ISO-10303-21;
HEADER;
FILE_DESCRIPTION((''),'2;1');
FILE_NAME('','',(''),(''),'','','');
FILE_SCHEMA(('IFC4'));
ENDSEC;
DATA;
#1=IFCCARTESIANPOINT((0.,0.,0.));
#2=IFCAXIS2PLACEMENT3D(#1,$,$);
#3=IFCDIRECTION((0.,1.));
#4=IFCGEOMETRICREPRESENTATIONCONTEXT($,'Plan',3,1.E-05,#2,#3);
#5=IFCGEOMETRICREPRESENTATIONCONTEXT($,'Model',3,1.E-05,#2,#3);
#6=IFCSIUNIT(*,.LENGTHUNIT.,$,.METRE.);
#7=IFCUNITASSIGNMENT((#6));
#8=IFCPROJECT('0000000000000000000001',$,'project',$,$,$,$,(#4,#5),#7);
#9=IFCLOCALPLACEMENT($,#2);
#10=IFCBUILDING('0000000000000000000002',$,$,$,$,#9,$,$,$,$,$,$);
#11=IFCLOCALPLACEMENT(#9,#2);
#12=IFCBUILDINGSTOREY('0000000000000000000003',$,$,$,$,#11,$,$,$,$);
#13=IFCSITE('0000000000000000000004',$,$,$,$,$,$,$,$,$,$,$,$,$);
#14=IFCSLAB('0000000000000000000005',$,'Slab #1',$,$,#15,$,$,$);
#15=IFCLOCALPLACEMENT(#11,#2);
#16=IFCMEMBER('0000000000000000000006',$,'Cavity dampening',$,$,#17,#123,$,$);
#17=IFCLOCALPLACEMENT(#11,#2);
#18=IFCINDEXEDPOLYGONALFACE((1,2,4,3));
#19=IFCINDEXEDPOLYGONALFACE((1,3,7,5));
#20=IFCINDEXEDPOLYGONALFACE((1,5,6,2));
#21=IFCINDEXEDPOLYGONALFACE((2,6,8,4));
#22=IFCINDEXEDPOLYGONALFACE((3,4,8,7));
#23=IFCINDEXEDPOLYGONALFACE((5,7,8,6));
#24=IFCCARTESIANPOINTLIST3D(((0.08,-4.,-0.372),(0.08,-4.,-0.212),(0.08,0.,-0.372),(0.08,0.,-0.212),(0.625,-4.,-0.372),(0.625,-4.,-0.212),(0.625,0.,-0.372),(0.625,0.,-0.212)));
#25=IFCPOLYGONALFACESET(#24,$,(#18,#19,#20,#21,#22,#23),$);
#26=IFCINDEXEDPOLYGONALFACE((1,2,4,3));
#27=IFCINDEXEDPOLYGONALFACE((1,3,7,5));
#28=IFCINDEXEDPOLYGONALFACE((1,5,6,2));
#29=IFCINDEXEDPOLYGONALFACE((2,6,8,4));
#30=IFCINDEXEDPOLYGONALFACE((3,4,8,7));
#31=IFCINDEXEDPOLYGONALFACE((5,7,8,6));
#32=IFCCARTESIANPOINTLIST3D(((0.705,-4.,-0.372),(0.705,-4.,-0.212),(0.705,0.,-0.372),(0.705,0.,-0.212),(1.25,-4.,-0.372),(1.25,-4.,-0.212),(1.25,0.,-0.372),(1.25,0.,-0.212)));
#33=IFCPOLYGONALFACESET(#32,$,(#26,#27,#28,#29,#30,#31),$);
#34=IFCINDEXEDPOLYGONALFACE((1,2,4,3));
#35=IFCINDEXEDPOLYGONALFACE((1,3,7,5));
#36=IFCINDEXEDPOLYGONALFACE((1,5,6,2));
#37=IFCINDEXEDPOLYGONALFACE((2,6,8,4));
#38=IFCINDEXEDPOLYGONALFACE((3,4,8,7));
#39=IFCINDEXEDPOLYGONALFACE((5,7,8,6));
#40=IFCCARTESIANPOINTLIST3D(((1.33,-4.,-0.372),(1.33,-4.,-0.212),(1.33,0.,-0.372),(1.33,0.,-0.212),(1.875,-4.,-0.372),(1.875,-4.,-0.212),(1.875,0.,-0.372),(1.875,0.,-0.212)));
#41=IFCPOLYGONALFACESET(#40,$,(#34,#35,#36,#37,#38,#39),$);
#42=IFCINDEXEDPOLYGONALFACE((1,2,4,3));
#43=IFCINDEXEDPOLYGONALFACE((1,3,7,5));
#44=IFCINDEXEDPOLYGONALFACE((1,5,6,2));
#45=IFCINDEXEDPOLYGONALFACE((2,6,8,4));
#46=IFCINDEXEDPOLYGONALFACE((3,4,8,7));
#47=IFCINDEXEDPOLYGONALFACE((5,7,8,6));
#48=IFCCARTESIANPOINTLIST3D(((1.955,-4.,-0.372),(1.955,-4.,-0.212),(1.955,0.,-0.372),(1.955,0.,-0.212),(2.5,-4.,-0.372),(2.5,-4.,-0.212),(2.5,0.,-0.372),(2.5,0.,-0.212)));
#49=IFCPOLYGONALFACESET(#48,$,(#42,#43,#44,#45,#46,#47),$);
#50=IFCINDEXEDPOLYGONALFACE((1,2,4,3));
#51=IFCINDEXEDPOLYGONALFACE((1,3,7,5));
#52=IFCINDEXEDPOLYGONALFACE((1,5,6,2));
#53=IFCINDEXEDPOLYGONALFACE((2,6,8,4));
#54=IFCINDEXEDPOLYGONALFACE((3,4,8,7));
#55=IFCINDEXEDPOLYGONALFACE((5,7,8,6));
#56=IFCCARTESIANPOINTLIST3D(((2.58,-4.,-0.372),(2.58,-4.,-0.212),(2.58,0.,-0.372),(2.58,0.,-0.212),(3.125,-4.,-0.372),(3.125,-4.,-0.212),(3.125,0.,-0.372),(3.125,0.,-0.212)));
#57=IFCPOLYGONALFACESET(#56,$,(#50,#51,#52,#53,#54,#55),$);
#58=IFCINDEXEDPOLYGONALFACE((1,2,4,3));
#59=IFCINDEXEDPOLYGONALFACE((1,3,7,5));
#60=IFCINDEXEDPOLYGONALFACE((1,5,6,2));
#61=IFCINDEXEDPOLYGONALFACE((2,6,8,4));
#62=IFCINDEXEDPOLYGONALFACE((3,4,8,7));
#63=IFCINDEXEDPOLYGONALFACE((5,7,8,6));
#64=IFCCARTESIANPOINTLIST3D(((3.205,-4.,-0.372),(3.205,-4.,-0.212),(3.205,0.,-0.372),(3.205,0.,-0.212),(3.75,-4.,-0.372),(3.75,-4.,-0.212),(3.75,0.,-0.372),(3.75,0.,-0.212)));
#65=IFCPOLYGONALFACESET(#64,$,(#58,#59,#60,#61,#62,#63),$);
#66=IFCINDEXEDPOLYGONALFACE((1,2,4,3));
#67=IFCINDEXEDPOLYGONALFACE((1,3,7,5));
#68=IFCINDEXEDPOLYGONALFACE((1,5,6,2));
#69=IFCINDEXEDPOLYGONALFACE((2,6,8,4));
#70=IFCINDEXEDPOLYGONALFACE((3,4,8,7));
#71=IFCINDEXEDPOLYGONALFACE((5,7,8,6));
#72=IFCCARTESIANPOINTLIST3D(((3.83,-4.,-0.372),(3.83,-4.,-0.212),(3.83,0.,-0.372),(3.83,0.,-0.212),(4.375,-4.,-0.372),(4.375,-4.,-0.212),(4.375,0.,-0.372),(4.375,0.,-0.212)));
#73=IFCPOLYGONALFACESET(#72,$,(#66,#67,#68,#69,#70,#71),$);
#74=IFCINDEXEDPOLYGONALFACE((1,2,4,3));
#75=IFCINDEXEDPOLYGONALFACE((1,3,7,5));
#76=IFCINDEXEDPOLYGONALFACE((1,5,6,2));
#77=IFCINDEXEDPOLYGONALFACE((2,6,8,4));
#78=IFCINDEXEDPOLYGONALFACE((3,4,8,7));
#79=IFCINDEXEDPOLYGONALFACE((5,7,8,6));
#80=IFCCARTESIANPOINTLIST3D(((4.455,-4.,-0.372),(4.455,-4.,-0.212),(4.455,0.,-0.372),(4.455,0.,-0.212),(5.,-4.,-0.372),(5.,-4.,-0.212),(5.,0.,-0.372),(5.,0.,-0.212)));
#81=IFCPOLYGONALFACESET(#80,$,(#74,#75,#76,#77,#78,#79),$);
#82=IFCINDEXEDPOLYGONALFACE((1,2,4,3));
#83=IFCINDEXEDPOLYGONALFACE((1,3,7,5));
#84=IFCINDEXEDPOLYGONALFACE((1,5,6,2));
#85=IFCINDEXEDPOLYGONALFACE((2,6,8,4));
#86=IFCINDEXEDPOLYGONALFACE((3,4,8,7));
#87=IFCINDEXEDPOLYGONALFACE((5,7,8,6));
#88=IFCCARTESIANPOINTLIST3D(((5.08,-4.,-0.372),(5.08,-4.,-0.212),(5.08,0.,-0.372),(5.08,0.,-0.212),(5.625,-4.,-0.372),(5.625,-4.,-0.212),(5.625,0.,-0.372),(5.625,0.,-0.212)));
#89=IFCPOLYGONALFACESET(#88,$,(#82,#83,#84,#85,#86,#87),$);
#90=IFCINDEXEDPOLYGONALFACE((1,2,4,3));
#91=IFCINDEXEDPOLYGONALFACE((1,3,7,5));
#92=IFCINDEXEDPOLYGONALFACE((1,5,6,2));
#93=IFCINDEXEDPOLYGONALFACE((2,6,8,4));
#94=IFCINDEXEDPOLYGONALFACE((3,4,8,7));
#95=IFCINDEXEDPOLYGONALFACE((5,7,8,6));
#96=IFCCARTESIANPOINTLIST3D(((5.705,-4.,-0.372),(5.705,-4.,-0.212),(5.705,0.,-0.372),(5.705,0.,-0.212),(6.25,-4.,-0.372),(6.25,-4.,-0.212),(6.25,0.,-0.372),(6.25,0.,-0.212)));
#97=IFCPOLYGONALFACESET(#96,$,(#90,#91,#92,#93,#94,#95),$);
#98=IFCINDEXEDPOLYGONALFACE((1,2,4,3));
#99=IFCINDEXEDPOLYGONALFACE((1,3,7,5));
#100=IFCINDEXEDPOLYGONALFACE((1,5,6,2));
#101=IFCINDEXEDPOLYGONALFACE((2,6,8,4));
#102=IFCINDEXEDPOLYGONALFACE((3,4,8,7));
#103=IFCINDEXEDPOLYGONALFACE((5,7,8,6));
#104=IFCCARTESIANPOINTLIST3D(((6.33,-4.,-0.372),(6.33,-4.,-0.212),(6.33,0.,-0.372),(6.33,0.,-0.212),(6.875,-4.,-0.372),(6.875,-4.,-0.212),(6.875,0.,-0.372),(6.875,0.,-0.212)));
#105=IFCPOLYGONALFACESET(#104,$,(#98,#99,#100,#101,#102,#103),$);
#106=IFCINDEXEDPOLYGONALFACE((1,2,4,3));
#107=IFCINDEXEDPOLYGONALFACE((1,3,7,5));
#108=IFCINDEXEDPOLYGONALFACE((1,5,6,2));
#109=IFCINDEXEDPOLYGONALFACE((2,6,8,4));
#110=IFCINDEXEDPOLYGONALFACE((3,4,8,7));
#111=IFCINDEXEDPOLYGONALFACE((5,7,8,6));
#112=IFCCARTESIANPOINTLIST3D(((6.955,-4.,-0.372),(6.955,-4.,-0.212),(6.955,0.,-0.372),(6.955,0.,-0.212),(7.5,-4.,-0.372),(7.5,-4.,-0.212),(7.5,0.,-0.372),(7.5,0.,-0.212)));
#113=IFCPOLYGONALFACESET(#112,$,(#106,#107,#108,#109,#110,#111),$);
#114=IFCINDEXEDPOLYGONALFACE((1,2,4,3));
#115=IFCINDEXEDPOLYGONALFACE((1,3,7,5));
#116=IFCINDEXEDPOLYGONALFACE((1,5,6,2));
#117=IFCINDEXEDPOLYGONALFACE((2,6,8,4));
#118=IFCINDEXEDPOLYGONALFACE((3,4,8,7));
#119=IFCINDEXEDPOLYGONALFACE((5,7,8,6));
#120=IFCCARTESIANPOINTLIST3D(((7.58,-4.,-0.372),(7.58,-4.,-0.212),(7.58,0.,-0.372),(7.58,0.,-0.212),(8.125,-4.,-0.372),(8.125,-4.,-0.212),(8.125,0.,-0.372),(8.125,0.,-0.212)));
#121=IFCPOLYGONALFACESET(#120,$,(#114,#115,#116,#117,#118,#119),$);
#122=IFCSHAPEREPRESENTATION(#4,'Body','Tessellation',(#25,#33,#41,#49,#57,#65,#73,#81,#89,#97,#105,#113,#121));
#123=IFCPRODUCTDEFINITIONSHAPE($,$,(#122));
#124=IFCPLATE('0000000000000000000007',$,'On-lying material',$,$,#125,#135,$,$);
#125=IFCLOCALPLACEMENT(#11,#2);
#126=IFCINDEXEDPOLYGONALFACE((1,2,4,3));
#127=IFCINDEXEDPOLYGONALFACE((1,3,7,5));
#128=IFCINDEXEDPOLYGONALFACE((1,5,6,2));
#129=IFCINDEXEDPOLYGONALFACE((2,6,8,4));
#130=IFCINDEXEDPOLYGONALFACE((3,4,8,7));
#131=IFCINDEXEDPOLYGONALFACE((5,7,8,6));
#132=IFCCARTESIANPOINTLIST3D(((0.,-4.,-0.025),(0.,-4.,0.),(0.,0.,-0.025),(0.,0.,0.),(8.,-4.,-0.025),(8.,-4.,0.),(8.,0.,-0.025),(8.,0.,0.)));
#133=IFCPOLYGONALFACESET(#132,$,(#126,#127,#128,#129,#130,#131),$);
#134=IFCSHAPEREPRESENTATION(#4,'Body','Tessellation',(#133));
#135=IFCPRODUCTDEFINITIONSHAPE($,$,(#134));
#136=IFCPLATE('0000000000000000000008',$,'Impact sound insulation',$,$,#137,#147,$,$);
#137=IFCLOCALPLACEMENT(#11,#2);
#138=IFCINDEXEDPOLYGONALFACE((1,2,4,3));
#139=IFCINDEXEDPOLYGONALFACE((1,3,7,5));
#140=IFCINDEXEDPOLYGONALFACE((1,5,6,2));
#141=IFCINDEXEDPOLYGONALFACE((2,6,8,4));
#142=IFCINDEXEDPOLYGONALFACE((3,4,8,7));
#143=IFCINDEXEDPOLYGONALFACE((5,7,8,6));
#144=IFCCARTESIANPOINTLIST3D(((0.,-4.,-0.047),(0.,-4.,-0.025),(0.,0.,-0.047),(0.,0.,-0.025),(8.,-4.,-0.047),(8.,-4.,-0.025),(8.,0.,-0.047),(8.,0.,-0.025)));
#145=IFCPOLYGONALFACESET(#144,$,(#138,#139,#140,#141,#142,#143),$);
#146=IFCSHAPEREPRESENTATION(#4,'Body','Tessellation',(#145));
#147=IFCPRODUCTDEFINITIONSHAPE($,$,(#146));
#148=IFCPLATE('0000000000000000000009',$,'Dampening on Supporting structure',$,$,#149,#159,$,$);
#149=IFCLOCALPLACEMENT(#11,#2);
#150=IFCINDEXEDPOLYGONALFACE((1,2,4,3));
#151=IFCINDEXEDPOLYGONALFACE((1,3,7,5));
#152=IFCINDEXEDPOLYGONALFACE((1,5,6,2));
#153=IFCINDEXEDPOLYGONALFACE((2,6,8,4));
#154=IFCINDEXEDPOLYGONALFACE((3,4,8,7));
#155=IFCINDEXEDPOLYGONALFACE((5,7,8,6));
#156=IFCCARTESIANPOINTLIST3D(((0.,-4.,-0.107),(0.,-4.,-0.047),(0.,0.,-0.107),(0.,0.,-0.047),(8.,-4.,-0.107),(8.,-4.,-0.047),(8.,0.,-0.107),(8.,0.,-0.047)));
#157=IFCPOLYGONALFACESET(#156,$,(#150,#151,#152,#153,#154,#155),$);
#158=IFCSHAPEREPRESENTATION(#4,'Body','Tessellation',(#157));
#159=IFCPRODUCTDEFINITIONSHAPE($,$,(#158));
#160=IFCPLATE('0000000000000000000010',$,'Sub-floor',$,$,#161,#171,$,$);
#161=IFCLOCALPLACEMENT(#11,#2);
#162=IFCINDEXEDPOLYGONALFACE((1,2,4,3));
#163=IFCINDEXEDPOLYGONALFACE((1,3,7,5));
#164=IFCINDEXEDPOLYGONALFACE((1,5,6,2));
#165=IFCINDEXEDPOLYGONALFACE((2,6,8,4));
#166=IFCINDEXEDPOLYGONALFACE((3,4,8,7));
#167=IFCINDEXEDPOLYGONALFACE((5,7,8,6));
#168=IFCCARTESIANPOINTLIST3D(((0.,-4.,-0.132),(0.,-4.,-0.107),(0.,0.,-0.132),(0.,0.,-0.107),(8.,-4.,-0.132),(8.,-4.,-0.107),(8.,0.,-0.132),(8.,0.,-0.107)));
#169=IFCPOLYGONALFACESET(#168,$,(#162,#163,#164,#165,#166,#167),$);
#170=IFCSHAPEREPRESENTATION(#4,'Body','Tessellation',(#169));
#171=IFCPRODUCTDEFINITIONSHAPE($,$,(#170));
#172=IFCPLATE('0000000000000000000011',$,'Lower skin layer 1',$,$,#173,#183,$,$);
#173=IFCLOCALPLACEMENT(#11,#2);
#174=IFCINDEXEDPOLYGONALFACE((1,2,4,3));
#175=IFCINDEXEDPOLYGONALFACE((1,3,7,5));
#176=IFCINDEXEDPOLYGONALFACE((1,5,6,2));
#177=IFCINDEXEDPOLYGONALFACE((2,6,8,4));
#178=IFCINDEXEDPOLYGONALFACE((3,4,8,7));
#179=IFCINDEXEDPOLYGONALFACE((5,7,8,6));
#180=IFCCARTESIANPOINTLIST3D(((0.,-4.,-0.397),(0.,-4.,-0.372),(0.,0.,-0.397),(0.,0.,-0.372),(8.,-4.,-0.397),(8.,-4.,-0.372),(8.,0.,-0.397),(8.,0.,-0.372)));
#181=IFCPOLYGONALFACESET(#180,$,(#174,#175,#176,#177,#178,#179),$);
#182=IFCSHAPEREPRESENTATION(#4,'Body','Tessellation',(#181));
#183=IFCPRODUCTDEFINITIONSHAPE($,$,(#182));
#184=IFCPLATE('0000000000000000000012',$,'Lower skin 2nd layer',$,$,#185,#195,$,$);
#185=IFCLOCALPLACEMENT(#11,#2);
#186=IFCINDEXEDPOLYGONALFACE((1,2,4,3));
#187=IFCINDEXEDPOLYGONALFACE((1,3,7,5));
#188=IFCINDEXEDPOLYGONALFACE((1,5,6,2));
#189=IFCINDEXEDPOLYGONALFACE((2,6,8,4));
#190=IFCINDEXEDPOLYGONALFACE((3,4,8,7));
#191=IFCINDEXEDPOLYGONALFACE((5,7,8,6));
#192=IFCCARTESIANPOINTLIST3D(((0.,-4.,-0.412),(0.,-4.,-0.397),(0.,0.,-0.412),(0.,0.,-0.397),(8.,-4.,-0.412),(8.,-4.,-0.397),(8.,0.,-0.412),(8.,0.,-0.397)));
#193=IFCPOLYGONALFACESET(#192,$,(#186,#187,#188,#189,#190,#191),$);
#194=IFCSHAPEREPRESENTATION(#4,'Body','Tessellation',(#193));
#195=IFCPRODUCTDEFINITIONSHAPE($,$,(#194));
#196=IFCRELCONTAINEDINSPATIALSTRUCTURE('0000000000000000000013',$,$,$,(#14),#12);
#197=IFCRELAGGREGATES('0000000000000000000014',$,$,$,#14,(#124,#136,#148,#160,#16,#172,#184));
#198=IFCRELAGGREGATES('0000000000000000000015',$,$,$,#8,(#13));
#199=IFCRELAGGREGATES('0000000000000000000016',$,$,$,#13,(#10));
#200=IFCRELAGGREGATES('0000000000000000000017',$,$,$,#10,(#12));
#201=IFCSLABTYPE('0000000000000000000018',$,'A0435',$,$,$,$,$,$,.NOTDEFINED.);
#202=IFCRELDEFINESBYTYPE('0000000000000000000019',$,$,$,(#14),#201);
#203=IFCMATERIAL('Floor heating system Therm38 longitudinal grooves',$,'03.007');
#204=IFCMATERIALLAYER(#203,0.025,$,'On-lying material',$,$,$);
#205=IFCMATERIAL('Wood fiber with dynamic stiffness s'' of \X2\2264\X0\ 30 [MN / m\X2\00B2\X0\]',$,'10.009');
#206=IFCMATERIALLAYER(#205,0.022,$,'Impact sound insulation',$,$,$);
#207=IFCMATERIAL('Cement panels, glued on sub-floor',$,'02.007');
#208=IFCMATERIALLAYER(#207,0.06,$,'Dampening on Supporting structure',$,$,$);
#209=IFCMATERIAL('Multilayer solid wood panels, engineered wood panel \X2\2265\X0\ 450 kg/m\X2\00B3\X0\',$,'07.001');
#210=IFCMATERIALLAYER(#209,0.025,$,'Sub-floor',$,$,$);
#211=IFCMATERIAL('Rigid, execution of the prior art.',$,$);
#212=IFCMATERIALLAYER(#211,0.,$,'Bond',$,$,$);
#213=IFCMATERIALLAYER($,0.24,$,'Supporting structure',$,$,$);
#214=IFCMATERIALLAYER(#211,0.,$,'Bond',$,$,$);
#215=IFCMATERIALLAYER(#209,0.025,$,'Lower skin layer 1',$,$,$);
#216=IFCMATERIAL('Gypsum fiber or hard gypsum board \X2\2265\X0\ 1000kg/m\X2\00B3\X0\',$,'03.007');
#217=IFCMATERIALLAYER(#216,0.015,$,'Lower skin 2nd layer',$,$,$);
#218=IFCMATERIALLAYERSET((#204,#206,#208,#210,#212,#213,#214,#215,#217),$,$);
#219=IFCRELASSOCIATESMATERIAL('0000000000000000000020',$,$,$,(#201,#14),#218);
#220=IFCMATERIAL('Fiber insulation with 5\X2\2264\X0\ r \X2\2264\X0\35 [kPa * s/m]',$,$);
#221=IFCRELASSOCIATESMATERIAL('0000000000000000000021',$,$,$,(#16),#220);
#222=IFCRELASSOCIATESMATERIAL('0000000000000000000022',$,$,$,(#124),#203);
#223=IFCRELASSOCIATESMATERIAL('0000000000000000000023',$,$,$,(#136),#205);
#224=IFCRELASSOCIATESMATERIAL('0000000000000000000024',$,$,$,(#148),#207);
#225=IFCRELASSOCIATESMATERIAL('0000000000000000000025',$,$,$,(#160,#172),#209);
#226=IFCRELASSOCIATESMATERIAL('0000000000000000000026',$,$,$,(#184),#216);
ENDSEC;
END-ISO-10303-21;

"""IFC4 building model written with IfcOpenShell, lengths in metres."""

from ifc_helpers import new_model, si_unit, direction, frame, frame_2d, origin, origin_with_axes, place, context, project, spatial, rectangle, extrude, material, layer, layer_set, type_object, element, aggregate, save


model = new_model("IFC4")

# Units and contexts
plan_context = context("Plan", 3, precision=1e-05, world=origin(), true_north=direction((0.0, 1.0)))
model_context = context("Model", 3, precision=1e-05, world=origin(), true_north=direction((0.0, 1.0)))
ifc_project = project(units=[si_unit("LENGTHUNIT", "METRE")], contexts=[plan_context, model_context])

# Site, building, storey
site = spatial("IfcSite", under=ifc_project)
building_placement = place(None, origin())
building = spatial("IfcBuilding", under=site, at=building_placement)
storey_placement = place(building_placement, origin())
storey = spatial("IfcBuildingStorey", under=building, at=storey_placement)

# Slab, member, plates
ifc_material_1 = material(Name="Floor heating system Therm38 longitudinal grooves", Category="03.007")
ifc_layer_1 = layer(ifc_material_1, 0.025, Name="On-lying material")
ifc_material_2 = material(Name="Wood fiber with dynamic stiffness s' of ≤ 30 [MN / m²]", Category="10.009")
ifc_layer_2 = layer(ifc_material_2, 0.022, Name="Impact sound insulation")
ifc_material_3 = material(Name="Cement panels, glued on sub-floor", Category="02.007")
ifc_layer_3 = layer(ifc_material_3, 0.06, Name="Dampening on Supporting structure")
ifc_material_4 = material(Name="Multilayer solid wood panels, engineered wood panel ≥ 450 kg/m³", Category="07.001")
ifc_layer_4 = layer(ifc_material_4, 0.025, Name="Sub-floor")
ifc_material_5 = material(Name="Rigid, execution of the prior art.")
ifc_layer_5 = layer(ifc_material_5, 0.0, Name="Bond")
ifc_layer_6 = layer(None, 0.24, Name="Supporting structure")
ifc_layer_7 = layer(ifc_material_5, 0.0, Name="Bond")
ifc_layer_8 = layer(ifc_material_4, 0.025, Name="Lower skin layer 1")
ifc_material_6 = material(Name="Gypsum fiber or hard gypsum board ≥ 1000kg/m³", Category="03.007")
ifc_layer_9 = layer(ifc_material_6, 0.015, Name="Lower skin 2nd layer")
ifc_layer_set = layer_set([ifc_layer_1, ifc_layer_2, ifc_layer_3, ifc_layer_4, ifc_layer_5, ifc_layer_6, ifc_layer_7, ifc_layer_8, ifc_layer_9])
slab_type = type_object("IfcSlabType", Name="A0435", PredefinedType="NOTDEFINED", material=ifc_layer_set)
slab_placement = place(None, frame((0.0, 0.0, 0.0), z_axis=(0.0, 0.0, -1.0), x_axis=(1.0, 0.0, 0.0)))
slab = element("IfcSlab", 1, at=slab_placement, inside=storey, type_object=slab_type, material=ifc_layer_set, Name="Slab #1")
ifc_material_7 = material(Name="Fiber insulation with 5≤ r ≤35 [kPa * s/m]")
member_1_placement = place(slab_placement, origin())
member_1 = element("IfcMember", 2, at=member_1_placement, material=ifc_material_7, Name="Cavity dampening", context=plan_context, shape_type="SweptSolid", body=[
    extrude(rectangle(XDim=0.545, YDim=0.16, at=frame_2d((0.2725, 0.08), x_axis=(1.0, 0.0))), frame((0.08, 4.0, 0.212), z_axis=(0.0, -1.0, 0.0), x_axis=(1.0, 0.0, 0.0)), (0.0, 0.0, 1.0), 4.0),
    extrude(rectangle(XDim=0.545, YDim=0.16, at=frame_2d((0.2725, 0.08), x_axis=(1.0, 0.0))), frame((0.705, 4.0, 0.212), z_axis=(0.0, -1.0, 0.0), x_axis=(1.0, 0.0, 0.0)), (0.0, 0.0, 1.0), 4.0),
    extrude(rectangle(XDim=0.545, YDim=0.16, at=frame_2d((0.2725, 0.08), x_axis=(1.0, 0.0))), frame((1.33, 4.0, 0.212), z_axis=(0.0, -1.0, 0.0), x_axis=(1.0, 0.0, 0.0)), (0.0, 0.0, 1.0), 4.0),
    extrude(rectangle(XDim=0.545, YDim=0.16, at=frame_2d((0.2725, 0.08), x_axis=(1.0, 0.0))), frame((1.955, 4.0, 0.212), z_axis=(0.0, -1.0, 0.0), x_axis=(1.0, 0.0, 0.0)), (0.0, 0.0, 1.0), 4.0),
    extrude(rectangle(XDim=0.545, YDim=0.16, at=frame_2d((0.2725, 0.08), x_axis=(1.0, 0.0))), frame((2.58, 4.0, 0.212), z_axis=(0.0, -1.0, 0.0), x_axis=(1.0, 0.0, 0.0)), (0.0, 0.0, 1.0), 4.0),
    extrude(rectangle(XDim=0.545, YDim=0.16, at=frame_2d((0.2725, 0.08), x_axis=(1.0, 0.0))), frame((3.205, 4.0, 0.212), z_axis=(0.0, -1.0, 0.0), x_axis=(1.0, 0.0, 0.0)), (0.0, 0.0, 1.0), 4.0),
    extrude(rectangle(XDim=0.545, YDim=0.16, at=frame_2d((0.2725, 0.08), x_axis=(1.0, 0.0))), frame((3.83, 4.0, 0.212), z_axis=(0.0, -1.0, 0.0), x_axis=(1.0, 0.0, 0.0)), (0.0, 0.0, 1.0), 4.0),
    extrude(rectangle(XDim=0.545, YDim=0.16, at=frame_2d((0.2725, 0.08), x_axis=(1.0, 0.0))), frame((4.455, 4.0, 0.212), z_axis=(0.0, -1.0, 0.0), x_axis=(1.0, 0.0, 0.0)), (0.0, 0.0, 1.0), 4.0),
    extrude(rectangle(XDim=0.545, YDim=0.16, at=frame_2d((0.2725, 0.08), x_axis=(1.0, 0.0))), frame((5.08, 4.0, 0.212), z_axis=(0.0, -1.0, 0.0), x_axis=(1.0, 0.0, 0.0)), (0.0, 0.0, 1.0), 4.0),
    extrude(rectangle(XDim=0.545, YDim=0.16, at=frame_2d((0.2725, 0.08), x_axis=(1.0, 0.0))), frame((5.705, 4.0, 0.212), z_axis=(0.0, -1.0, 0.0), x_axis=(1.0, 0.0, 0.0)), (0.0, 0.0, 1.0), 4.0),
    extrude(rectangle(XDim=0.545, YDim=0.16, at=frame_2d((0.2725, 0.08), x_axis=(1.0, 0.0))), frame((6.33, 4.0, 0.212), z_axis=(0.0, -1.0, 0.0), x_axis=(1.0, 0.0, 0.0)), (0.0, 0.0, 1.0), 4.0),
    extrude(rectangle(XDim=0.545, YDim=0.16, at=frame_2d((0.2725, 0.08), x_axis=(1.0, 0.0))), frame((6.955, 4.0, 0.212), z_axis=(0.0, -1.0, 0.0), x_axis=(1.0, 0.0, 0.0)), (0.0, 0.0, 1.0), 4.0),
    extrude(rectangle(XDim=0.545, YDim=0.16, at=frame_2d((0.2725, 0.08), x_axis=(1.0, 0.0))), frame((7.58, 4.0, 0.212), z_axis=(0.0, -1.0, 0.0), x_axis=(1.0, 0.0, 0.0)), (0.0, 0.0, 1.0), 4.0),
])
plate_1_placement = place(slab_placement, origin())
plate_1 = element("IfcPlate", 3, at=plate_1_placement, material=ifc_material_1, Name="On-lying material", context=plan_context, shape_type="SweptSolid", body=[
    extrude(rectangle(XDim=8.0, YDim=4.0, at=frame_2d((4.0, 2.0), x_axis=(1.0, 0.0))), origin_with_axes(), (0.0, 0.0, 1.0), 0.025),
])
plate_2_placement = place(slab_placement, origin())
plate_2 = element("IfcPlate", 4, at=plate_2_placement, material=ifc_material_2, Name="Impact sound insulation", context=plan_context, shape_type="SweptSolid", body=[
    extrude(rectangle(XDim=8.0, YDim=4.0, at=frame_2d((4.0, 2.0), x_axis=(1.0, 0.0))), frame((0.0, 0.0, 0.025), z_axis=(0.0, 0.0, 1.0), x_axis=(1.0, 0.0, 0.0)), (0.0, 0.0, 1.0), 0.022),
])
plate_3_placement = place(slab_placement, origin())
plate_3 = element("IfcPlate", 5, at=plate_3_placement, material=ifc_material_3, Name="Dampening on Supporting structure", context=plan_context, shape_type="SweptSolid", body=[
    extrude(rectangle(XDim=8.0, YDim=4.0, at=frame_2d((4.0, 2.0), x_axis=(1.0, 0.0))), frame((0.0, 0.0, 0.047), z_axis=(0.0, 0.0, 1.0), x_axis=(1.0, 0.0, 0.0)), (0.0, 0.0, 1.0), 0.06),
])
plate_4_placement = place(slab_placement, origin())
plate_4 = element("IfcPlate", 6, at=plate_4_placement, material=ifc_material_4, Name="Sub-floor", context=plan_context, shape_type="SweptSolid", body=[
    extrude(rectangle(XDim=8.0, YDim=4.0, at=frame_2d((4.0, 2.0), x_axis=(1.0, 0.0))), frame((0.0, 0.0, 0.107), z_axis=(0.0, 0.0, 1.0), x_axis=(1.0, 0.0, 0.0)), (0.0, 0.0, 1.0), 0.025),
])
plate_5_placement = place(slab_placement, origin())
plate_5 = element("IfcPlate", 7, at=plate_5_placement, material=ifc_material_4, Name="Lower skin layer 1", context=plan_context, shape_type="SweptSolid", body=[
    extrude(rectangle(XDim=8.0, YDim=4.0, at=frame_2d((4.0, 2.0), x_axis=(1.0, 0.0))), frame((0.0, 0.0, 0.372), z_axis=(0.0, 0.0, 1.0), x_axis=(1.0, 0.0, 0.0)), (0.0, 0.0, 1.0), 0.025),
])
plate_6_placement = place(slab_placement, origin())
plate_6 = element("IfcPlate", 8, at=plate_6_placement, material=ifc_material_6, Name="Lower skin 2nd layer", context=plan_context, shape_type="SweptSolid", body=[
    extrude(rectangle(XDim=8.0, YDim=4.0, at=frame_2d((4.0, 2.0), x_axis=(1.0, 0.0))), frame((0.0, 0.0, 0.397), z_axis=(0.0, 0.0, 1.0), x_axis=(1.0, 0.0, 0.0)), (0.0, 0.0, 1.0), 0.015),
])
aggregate(slab, [plate_1, plate_2, plate_3, plate_4, member_1, plate_5, plate_6])

save(model, "model.ifc")
